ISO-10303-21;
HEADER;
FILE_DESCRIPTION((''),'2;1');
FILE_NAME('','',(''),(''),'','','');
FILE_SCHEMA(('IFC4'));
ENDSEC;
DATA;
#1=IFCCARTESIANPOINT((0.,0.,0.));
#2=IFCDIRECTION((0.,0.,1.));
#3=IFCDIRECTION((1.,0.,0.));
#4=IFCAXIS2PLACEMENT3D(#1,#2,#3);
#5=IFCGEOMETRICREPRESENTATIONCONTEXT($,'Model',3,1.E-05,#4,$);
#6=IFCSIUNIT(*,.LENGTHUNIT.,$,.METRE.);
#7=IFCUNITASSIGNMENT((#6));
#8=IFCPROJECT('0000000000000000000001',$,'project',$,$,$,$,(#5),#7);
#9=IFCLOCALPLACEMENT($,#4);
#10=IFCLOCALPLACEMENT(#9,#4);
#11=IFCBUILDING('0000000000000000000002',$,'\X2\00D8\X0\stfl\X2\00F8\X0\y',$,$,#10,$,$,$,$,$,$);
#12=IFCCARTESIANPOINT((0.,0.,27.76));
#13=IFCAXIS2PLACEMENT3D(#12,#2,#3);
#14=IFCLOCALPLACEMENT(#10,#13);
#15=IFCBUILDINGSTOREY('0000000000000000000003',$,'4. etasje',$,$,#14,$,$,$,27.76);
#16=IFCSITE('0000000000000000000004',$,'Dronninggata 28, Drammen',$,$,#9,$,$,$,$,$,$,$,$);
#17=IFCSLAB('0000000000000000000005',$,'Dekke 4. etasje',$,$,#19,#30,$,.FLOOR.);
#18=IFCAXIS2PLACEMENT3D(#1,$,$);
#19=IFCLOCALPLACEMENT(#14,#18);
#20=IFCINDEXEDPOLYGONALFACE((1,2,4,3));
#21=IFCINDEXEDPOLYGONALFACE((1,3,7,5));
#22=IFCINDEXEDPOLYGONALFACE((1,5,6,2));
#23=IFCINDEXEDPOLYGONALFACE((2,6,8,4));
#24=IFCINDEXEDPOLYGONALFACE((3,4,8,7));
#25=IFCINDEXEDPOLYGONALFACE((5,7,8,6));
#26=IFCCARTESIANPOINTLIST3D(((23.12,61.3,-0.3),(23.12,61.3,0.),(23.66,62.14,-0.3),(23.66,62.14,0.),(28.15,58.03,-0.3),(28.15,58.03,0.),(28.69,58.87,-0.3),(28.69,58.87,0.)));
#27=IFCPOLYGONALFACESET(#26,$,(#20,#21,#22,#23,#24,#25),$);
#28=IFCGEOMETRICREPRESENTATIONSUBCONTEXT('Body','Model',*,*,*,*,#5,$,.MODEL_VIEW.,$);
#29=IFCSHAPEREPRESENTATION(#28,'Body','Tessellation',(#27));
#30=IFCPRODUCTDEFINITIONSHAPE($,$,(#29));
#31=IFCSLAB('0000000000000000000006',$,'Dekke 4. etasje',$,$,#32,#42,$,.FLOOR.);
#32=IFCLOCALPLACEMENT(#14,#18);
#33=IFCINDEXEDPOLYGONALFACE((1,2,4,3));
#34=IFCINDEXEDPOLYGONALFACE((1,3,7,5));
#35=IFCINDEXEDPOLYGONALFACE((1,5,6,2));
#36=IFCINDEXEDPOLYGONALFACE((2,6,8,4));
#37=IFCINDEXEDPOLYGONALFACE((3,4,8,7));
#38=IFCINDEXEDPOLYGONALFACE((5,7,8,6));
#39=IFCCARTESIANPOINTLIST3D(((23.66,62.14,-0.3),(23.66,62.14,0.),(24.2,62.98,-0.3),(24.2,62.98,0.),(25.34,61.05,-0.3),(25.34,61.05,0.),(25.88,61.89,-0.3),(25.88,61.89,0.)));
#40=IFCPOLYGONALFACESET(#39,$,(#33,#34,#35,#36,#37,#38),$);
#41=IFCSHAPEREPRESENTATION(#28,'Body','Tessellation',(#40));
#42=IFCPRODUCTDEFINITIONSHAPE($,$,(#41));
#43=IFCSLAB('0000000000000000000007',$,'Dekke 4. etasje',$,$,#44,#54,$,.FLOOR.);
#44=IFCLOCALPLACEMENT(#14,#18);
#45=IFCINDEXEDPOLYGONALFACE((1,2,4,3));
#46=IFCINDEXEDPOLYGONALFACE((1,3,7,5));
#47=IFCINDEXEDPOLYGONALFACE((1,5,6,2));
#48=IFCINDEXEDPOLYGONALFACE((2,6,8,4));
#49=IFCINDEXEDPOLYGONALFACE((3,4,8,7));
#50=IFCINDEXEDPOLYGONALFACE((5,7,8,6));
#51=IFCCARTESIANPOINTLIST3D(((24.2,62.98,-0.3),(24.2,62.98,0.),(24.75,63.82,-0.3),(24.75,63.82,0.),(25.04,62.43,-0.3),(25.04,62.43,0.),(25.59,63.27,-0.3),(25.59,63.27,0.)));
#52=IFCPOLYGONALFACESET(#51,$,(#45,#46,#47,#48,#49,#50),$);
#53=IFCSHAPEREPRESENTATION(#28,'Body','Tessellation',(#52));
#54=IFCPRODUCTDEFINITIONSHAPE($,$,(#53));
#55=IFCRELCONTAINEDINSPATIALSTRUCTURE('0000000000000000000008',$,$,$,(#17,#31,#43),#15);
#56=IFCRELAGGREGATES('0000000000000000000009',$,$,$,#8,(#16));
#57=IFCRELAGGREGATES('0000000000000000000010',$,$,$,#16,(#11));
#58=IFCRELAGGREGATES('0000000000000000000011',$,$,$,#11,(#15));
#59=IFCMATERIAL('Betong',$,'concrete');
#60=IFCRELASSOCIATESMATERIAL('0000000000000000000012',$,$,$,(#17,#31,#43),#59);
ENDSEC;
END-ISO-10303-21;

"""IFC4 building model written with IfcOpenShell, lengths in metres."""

from ifc_helpers import new_model, si_unit, frame, origin_with_axes, place, context, subcontext, project, spatial, polyline, outline, extrude, material, element, save


model = new_model("IFC4")

# Units and contexts
model_context = context("Model", 3, precision=1e-05, world=origin_with_axes())
body_context = subcontext(model_context, "Body", "Model", "MODEL_VIEW")
ifc_project = project(units=[si_unit("LENGTHUNIT", "METRE")], contexts=[model_context])

# Site, building, storey
site_placement = place(None, origin_with_axes())
site = spatial("IfcSite", under=ifc_project, at=site_placement, Name="Dronninggata 28, Drammen")
building_placement = place(site_placement, origin_with_axes())
building = spatial("IfcBuilding", under=site, at=building_placement, Name="Østfløy")
storey_placement = place(building_placement, frame((0.0, 0.0, 27.76), z_axis=(0.0, 0.0, 1.0), x_axis=(1.0, 0.0, 0.0)))
storey = spatial("IfcBuildingStorey", under=building, at=storey_placement, Name="4. etasje", Elevation=27.76)

# Slabs
ifc_material = material(Name="Betong", Category="concrete")
slab_1_placement = place(storey_placement, frame((0.0, 0.0, -27.76), z_axis=(0.0, 0.0, 1.0), x_axis=(1.0, 0.0, 0.0)))
element("IfcSlab", 1, at=slab_1_placement, inside=storey, material=ifc_material, Name="Dekke 4. etasje", PredefinedType="FLOOR", context=body_context, shape_type="SweptSolid", body=[
    extrude(outline(polyline([(28.15, 58.03), (28.69, 58.87), (23.66, 62.14), (23.12, 61.3), (28.15, 58.03)])), frame((0.0, 0.0, 27.46)), (0.0, 0.0, 1.0), 0.3),
])
slab_2_placement = place(storey_placement, frame((0.0, 0.0, -27.76), z_axis=(0.0, 0.0, 1.0), x_axis=(1.0, 0.0, 0.0)))
element("IfcSlab", 2, at=slab_2_placement, inside=storey, material=ifc_material, Name="Dekke 4. etasje", PredefinedType="FLOOR", context=body_context, shape_type="SweptSolid", body=[
    extrude(outline(polyline([(25.34, 61.05), (25.88, 61.89), (24.2, 62.98), (23.66, 62.14), (25.34, 61.05)])), frame((0.0, 0.0, 27.46)), (0.0, 0.0, 1.0), 0.3),
])
slab_3_placement = place(storey_placement, frame((0.0, 0.0, -27.76), z_axis=(0.0, 0.0, 1.0), x_axis=(1.0, 0.0, 0.0)))
element("IfcSlab", 3, at=slab_3_placement, inside=storey, material=ifc_material, Name="Dekke 4. etasje", PredefinedType="FLOOR", context=body_context, shape_type="SweptSolid", body=[
    extrude(outline(polyline([(25.04, 62.43), (25.59, 63.27), (24.75, 63.82), (24.2, 62.98), (25.04, 62.43)])), frame((0.0, 0.0, 27.46)), (0.0, 0.0, 1.0), 0.3),
])

save(model, "model.ifc")
